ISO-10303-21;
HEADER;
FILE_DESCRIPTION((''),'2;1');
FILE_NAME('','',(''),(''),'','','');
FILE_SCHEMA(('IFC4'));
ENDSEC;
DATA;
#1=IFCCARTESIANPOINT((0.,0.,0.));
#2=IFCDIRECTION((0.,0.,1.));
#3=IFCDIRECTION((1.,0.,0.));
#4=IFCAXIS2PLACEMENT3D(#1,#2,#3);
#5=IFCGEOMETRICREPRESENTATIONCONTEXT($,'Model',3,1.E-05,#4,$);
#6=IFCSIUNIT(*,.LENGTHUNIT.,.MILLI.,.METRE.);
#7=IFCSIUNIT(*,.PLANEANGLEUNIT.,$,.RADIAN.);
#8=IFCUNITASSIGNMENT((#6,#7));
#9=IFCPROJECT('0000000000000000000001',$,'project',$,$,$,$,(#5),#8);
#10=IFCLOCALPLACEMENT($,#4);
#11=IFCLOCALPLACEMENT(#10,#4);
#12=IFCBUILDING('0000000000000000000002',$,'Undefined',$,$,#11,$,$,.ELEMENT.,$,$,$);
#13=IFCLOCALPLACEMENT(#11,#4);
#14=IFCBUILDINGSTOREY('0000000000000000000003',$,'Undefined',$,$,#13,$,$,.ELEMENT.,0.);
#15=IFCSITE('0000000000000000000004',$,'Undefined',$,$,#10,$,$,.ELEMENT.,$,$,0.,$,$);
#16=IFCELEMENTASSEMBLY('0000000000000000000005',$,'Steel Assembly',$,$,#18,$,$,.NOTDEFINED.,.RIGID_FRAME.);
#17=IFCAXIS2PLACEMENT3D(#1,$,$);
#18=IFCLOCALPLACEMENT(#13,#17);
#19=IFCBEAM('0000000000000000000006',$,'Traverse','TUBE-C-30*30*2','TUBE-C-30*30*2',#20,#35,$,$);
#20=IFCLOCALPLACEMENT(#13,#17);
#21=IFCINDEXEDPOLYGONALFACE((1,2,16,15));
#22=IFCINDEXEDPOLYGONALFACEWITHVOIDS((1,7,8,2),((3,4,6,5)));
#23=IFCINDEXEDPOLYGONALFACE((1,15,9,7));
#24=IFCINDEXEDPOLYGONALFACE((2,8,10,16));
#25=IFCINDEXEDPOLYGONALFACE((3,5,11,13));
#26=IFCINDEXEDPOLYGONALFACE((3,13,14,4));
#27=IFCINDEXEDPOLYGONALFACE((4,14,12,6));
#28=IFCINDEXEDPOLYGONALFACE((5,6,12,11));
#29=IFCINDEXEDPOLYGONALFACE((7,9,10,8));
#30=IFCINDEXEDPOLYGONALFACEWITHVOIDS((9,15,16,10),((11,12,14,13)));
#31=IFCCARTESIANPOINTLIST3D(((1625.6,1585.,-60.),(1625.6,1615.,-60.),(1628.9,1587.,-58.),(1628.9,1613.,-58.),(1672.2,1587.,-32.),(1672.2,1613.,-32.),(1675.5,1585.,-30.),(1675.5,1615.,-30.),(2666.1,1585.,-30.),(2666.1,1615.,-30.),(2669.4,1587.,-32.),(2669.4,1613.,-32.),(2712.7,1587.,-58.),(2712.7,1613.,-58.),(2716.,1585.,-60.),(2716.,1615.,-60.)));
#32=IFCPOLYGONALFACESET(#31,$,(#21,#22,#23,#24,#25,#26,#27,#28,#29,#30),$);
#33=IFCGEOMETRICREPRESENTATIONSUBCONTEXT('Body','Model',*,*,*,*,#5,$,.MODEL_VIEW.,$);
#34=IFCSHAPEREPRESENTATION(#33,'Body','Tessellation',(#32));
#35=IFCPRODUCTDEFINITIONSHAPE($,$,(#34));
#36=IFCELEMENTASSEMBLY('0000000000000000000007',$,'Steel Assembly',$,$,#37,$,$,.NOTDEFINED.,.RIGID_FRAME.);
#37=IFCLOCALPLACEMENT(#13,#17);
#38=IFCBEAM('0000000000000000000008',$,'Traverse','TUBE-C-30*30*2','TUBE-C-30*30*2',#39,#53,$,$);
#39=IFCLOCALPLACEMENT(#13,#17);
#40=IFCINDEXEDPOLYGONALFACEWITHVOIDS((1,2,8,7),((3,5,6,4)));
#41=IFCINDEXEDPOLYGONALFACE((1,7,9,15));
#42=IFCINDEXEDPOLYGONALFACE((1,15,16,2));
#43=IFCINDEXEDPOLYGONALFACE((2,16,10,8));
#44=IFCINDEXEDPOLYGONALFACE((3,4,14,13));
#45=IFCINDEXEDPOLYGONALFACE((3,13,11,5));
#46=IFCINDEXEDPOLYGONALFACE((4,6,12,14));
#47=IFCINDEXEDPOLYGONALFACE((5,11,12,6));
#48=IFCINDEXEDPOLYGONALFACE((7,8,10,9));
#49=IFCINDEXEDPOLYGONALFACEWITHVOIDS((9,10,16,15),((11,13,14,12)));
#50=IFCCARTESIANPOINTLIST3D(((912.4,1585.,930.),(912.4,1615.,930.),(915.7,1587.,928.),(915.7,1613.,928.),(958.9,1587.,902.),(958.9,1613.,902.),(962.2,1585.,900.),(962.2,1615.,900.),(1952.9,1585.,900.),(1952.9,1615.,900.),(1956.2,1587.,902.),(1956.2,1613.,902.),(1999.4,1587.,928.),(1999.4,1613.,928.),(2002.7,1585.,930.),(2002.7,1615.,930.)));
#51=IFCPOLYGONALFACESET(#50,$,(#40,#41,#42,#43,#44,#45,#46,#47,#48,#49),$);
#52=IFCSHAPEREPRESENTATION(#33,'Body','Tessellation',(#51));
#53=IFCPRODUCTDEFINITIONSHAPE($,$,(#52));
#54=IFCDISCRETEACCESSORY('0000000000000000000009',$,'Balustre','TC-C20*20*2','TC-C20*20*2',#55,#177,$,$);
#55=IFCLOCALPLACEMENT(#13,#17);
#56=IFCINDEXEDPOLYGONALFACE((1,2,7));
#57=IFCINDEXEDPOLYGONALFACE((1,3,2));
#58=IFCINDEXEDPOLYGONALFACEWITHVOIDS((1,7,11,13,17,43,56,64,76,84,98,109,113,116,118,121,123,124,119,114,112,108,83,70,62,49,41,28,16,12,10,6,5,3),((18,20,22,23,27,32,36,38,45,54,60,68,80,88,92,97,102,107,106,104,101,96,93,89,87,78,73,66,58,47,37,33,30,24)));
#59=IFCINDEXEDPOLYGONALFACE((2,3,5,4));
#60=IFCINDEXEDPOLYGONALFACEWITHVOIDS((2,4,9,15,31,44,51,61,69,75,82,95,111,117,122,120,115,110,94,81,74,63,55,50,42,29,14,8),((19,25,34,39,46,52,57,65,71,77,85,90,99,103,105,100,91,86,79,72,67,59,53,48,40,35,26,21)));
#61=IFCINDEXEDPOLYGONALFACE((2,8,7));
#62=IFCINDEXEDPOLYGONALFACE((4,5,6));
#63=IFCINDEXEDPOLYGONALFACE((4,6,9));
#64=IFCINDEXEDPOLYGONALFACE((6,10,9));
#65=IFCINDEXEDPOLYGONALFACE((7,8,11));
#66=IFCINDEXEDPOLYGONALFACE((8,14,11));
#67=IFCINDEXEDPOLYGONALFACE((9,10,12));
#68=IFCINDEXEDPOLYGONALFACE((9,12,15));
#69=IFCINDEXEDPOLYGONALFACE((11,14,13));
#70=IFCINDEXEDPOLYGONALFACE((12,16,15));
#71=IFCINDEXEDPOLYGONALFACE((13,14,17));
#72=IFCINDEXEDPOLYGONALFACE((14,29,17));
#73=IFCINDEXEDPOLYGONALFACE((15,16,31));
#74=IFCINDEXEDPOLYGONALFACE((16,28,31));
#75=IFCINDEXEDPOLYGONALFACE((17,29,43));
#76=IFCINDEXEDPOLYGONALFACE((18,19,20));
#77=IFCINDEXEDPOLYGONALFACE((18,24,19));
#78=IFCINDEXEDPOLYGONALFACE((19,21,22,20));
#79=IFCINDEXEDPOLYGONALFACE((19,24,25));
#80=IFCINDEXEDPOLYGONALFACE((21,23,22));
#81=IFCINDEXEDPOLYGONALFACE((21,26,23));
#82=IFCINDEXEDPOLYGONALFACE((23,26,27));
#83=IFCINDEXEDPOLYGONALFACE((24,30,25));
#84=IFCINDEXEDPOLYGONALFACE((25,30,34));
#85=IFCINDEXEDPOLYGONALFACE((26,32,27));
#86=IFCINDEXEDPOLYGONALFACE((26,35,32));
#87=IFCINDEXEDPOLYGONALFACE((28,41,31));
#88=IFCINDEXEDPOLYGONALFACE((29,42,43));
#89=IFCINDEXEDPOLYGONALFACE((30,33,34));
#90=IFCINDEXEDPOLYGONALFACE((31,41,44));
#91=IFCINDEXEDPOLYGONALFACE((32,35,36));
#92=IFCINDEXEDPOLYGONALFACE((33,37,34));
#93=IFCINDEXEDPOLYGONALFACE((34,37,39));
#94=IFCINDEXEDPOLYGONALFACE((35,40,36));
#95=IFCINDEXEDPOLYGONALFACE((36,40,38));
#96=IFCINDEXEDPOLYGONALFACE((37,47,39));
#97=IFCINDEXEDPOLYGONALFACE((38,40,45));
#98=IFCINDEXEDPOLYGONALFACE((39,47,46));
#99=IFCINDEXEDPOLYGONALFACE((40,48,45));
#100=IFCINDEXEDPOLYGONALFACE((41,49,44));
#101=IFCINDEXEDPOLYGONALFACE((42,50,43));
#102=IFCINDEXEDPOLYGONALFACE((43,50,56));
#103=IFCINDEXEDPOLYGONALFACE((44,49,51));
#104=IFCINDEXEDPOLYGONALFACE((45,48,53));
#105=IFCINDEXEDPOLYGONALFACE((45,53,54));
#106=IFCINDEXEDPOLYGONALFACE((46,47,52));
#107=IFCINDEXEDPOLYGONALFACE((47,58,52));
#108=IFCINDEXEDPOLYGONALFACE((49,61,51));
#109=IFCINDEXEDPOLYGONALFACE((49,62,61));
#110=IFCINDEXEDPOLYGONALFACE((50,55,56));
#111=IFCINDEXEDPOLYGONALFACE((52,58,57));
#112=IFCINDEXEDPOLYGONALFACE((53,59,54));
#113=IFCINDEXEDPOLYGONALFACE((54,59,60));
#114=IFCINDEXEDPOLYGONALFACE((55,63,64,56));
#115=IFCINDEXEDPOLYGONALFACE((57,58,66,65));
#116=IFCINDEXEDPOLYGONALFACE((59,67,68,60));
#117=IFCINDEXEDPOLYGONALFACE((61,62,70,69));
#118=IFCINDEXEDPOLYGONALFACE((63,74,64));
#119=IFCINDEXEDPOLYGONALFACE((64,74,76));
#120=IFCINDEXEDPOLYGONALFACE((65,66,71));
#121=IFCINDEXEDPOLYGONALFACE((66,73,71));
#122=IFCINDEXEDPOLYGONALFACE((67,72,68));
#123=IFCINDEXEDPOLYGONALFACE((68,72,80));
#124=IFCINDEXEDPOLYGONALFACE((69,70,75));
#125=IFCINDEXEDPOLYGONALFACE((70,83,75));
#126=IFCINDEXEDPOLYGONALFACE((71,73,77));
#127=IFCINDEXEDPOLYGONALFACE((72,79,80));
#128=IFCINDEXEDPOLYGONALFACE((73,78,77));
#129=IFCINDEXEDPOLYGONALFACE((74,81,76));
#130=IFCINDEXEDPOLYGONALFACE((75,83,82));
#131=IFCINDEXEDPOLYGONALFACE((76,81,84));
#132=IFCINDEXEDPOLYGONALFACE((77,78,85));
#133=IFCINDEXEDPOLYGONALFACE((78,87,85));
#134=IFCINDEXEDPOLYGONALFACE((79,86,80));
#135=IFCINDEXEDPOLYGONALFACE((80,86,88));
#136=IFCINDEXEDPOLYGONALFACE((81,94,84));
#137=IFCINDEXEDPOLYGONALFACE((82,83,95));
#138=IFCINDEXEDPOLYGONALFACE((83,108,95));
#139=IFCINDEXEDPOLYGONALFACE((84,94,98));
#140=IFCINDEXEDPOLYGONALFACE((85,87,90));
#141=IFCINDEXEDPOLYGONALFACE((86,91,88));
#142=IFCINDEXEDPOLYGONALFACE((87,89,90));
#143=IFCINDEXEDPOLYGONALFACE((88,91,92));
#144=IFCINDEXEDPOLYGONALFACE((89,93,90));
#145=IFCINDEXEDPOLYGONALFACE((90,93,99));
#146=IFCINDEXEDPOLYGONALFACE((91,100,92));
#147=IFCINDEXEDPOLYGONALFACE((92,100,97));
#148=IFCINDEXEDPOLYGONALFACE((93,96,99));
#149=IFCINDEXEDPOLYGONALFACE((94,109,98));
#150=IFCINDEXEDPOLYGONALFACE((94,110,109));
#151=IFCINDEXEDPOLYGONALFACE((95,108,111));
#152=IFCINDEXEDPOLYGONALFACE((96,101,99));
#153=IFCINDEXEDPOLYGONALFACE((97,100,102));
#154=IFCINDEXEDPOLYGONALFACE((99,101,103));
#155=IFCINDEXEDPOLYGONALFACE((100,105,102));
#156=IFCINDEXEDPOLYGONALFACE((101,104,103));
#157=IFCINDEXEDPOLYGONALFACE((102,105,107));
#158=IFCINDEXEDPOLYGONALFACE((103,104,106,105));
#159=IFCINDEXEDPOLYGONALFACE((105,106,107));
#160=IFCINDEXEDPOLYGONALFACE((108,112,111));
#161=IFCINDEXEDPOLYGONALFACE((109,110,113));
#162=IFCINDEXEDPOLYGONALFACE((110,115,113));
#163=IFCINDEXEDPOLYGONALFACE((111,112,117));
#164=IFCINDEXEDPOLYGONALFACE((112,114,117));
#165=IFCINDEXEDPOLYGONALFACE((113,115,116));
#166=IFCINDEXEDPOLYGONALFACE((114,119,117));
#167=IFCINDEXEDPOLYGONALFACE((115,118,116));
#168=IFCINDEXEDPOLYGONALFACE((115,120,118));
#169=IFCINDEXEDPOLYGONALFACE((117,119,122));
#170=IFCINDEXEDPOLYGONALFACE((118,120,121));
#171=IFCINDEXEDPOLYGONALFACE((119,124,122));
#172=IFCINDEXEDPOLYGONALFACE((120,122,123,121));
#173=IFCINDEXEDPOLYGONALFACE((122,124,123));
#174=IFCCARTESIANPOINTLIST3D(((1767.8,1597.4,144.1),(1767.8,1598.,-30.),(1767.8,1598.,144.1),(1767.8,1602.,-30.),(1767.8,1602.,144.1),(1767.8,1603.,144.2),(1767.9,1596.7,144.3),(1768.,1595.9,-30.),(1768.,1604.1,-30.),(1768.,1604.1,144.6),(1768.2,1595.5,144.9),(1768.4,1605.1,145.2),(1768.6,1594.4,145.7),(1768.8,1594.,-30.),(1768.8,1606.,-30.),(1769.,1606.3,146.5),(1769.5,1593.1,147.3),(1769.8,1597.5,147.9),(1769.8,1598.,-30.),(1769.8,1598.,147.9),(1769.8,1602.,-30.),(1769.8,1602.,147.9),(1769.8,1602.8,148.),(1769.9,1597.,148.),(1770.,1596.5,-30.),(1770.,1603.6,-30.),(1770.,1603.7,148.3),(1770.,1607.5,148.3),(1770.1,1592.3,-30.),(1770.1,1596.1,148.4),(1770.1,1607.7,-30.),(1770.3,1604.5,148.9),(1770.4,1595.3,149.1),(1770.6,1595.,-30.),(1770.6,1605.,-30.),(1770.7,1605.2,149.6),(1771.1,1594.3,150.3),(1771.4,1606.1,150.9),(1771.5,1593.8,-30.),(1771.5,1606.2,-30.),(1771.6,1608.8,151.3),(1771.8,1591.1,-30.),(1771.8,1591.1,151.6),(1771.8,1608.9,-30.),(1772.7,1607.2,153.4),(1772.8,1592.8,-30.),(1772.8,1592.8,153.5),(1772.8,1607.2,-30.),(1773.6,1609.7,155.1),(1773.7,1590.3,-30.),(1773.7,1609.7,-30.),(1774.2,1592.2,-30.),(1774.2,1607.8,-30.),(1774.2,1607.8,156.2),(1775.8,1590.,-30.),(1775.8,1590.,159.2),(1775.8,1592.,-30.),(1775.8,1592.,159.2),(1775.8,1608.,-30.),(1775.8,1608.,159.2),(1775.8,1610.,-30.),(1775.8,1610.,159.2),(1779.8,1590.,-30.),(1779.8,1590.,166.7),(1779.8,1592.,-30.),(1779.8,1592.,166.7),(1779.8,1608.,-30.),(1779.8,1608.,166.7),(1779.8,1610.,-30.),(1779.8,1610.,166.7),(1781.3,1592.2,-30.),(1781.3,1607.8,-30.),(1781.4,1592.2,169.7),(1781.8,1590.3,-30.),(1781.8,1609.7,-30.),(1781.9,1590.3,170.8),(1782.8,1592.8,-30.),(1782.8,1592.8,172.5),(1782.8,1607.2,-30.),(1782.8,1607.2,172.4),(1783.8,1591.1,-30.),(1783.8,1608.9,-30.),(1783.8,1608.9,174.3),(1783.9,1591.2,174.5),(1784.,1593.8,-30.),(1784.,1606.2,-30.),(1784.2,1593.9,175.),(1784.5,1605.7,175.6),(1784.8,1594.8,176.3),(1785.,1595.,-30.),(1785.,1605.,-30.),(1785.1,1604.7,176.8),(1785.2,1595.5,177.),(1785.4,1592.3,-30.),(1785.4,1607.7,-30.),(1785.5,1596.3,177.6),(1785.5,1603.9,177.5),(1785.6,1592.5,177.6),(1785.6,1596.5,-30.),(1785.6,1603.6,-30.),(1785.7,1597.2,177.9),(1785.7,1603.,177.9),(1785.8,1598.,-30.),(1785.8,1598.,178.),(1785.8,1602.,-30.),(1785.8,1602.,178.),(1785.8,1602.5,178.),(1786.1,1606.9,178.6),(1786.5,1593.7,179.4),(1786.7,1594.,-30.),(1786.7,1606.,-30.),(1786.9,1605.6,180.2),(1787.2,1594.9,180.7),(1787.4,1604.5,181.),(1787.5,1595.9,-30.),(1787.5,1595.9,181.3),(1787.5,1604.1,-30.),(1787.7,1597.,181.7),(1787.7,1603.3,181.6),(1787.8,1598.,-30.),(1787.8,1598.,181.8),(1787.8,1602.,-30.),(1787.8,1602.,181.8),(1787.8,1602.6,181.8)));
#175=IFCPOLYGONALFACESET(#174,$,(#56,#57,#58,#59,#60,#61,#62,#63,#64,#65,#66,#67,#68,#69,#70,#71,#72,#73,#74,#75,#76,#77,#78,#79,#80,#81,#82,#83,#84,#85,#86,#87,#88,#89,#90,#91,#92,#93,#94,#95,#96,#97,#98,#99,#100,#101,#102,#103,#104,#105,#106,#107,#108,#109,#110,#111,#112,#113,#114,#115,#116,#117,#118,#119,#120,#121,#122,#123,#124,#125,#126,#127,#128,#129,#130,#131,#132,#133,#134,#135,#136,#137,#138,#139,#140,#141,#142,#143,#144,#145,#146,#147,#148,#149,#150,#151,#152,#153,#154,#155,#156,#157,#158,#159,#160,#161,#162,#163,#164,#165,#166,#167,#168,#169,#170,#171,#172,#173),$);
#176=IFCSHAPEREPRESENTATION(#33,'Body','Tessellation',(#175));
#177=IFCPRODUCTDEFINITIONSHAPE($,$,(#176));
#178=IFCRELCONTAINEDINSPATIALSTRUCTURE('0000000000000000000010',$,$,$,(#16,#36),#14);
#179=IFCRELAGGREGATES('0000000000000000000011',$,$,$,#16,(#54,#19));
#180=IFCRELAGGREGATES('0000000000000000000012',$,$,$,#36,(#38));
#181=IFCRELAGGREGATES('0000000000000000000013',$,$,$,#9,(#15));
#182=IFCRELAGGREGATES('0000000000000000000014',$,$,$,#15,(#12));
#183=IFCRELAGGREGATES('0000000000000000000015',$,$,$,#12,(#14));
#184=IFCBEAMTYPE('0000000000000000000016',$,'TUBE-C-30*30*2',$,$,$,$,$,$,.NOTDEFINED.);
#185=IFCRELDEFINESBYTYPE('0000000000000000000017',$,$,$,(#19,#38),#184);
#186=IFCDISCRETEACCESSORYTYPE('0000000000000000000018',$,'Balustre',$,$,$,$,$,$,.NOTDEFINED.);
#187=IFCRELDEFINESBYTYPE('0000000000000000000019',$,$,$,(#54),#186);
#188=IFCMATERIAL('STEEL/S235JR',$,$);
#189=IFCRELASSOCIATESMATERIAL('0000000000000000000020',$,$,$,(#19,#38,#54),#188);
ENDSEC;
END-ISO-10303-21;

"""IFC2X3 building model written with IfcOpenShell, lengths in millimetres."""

from ifc_helpers import new_model, si_unit, frame, origin_with_axes, origin_2d_with_axis, place, context, subcontext, project, spatial, hollow_rectangle, extrude, clip, halfspace, material, type_object, element, aggregate, save


model = new_model("IFC2X3")

# Units and contexts
model_context = context("Model", 3, precision=1e-05, world=origin_with_axes())
body_context = subcontext(model_context, "Body", "Model", "MODEL_VIEW")
ifc_project = project(units=[si_unit("LENGTHUNIT", "METRE", prefix="MILLI"), si_unit("PLANEANGLEUNIT", "RADIAN")], contexts=[model_context])

# Site, building, storey
site_placement = place(None, origin_with_axes())
site = spatial("IfcSite", under=ifc_project, at=site_placement, Name="Undefined", CompositionType="ELEMENT", RefElevation=0.0)
building_placement = place(site_placement, origin_with_axes())
building = spatial("IfcBuilding", under=site, at=building_placement, Name="Undefined", CompositionType="ELEMENT")
storey_placement = place(building_placement, origin_with_axes())
storey = spatial("IfcBuildingStorey", under=building, at=storey_placement, Name="Undefined", CompositionType="ELEMENT", Elevation=0.0)

# Element assemblies, beams
assembly_1_placement = place(storey_placement, origin_with_axes())
assembly_1 = element("IfcElementAssembly", 1, at=assembly_1_placement, inside=storey, Name="Steel Assembly", AssemblyPlace="NOTDEFINED", PredefinedType="RIGID_FRAME")
ifc_material = material(Name="STEEL/S235JR")
beam_type = type_object("IfcBeamType", Name="TUBE-C-30*30*2", PredefinedType="NOTDEFINED")
beam_1_placement = place(assembly_1_placement, frame((1600.2, 1600.0, -45.0), z_axis=(0.000011, -1.0, 0.0), x_axis=(1.0, 0.000011, 0.0)))
beam_1 = element("IfcBeam", 2, at=beam_1_placement, type_object=beam_type, material=ifc_material, Name="Traverse", Description="TUBE-C-30*30*2", ObjectType="TUBE-C-30*30*2", context=body_context, shape_type="Clipping", body=[
    clip(clip(extrude(hollow_rectangle(XDim=30.0, YDim=30.0, WallThickness=2.0, at=origin_2d_with_axis()), frame((1141.2, 0.0, 0.0), z_axis=(-1.0, 0.0, 0.0), x_axis=(0.0, -1.0, 0.0)), (0.0, 0.0, 1.0), 1141.2), halfspace(frame((1065.9, 15.0, 0.0), z_axis=(0.515548, 0.856861, 0.000003), x_axis=(0.000005, 0.0, -1.0)), False)), halfspace(frame((75.3, 15.0, 0.0), z_axis=(0.515548, -0.856861, 0.000003), x_axis=(0.000005, 0.0, -1.0)), True)),
])
assembly_2_placement = place(storey_placement, origin_with_axes())
assembly_2 = element("IfcElementAssembly", 3, at=assembly_2_placement, inside=storey, Name="Steel Assembly", AssemblyPlace="NOTDEFINED", PredefinedType="RIGID_FRAME")
beam_2_placement = place(assembly_2_placement, frame((2028.1, 1600.0, 915.0), z_axis=(0.0, -1.0, 0.0), x_axis=(-1.0, 0.0, 0.0)))
beam_2 = element("IfcBeam", 4, at=beam_2_placement, type_object=beam_type, material=ifc_material, Name="Traverse", Description="TUBE-C-30*30*2", ObjectType="TUBE-C-30*30*2", context=body_context, shape_type="Clipping", body=[
    clip(clip(extrude(hollow_rectangle(XDim=30.0, YDim=30.0, WallThickness=2.0, at=origin_2d_with_axis()), frame((1141.2, 0.0, 0.0), z_axis=(-1.0, 0.0, 0.0), x_axis=(0.0, -1.0, 0.0)), (0.0, 0.0, 1.0), 1141.2), halfspace(frame((1065.9, 15.0, 0.0), z_axis=(0.515548, 0.856861, 0.000003), x_axis=(0.000005, 0.0, -1.0)), False)), halfspace(frame((75.3, 15.0, 0.0), z_axis=(0.515548, -0.856861, 0.000003), x_axis=(0.000005, 0.0, -1.0)), True)),
])

# Discrete accessory
discrete_accessory_type_1 = type_object("IfcDiscreteAccessoryType", Name="Balustre")
discrete_accessory_1_placement = place(assembly_1_placement, frame((1777.8, 1600.0, -30.0), z_axis=(0.0, 0.0, 1.0), x_axis=(1.0, 0.0, 0.0)))
discrete_accessory_1 = element("IfcDiscreteAccessory", 5, at=discrete_accessory_1_placement, type_object=discrete_accessory_type_1, material=ifc_material, Name="Balustre", Description="TC-C20*20*2", ObjectType="TC-C20*20*2", context=body_context, shape_type="Clipping", body=[
    clip(extrude(hollow_rectangle(XDim=20.0, YDim=20.0, WallThickness=2.0, InnerFilletRadius=6.0, OuterFilletRadius=8.0, at=origin_2d_with_axis()), frame((0.0, 0.0, 212.0), z_axis=(0.0, 0.0, -1.0), x_axis=(-1.0, 0.0, 0.0)), (0.0, 0.0, 1.0), 212.0), halfspace(frame((15.1, 0.0, 221.5), z_axis=(0.883506, 0.000005, -0.46842), x_axis=(-0.000005, 1.0, 0.0)), True)),
])
aggregate(assembly_1, [discrete_accessory_1, beam_1])
aggregate(assembly_2, [beam_2])

save(model, "model.ifc")
